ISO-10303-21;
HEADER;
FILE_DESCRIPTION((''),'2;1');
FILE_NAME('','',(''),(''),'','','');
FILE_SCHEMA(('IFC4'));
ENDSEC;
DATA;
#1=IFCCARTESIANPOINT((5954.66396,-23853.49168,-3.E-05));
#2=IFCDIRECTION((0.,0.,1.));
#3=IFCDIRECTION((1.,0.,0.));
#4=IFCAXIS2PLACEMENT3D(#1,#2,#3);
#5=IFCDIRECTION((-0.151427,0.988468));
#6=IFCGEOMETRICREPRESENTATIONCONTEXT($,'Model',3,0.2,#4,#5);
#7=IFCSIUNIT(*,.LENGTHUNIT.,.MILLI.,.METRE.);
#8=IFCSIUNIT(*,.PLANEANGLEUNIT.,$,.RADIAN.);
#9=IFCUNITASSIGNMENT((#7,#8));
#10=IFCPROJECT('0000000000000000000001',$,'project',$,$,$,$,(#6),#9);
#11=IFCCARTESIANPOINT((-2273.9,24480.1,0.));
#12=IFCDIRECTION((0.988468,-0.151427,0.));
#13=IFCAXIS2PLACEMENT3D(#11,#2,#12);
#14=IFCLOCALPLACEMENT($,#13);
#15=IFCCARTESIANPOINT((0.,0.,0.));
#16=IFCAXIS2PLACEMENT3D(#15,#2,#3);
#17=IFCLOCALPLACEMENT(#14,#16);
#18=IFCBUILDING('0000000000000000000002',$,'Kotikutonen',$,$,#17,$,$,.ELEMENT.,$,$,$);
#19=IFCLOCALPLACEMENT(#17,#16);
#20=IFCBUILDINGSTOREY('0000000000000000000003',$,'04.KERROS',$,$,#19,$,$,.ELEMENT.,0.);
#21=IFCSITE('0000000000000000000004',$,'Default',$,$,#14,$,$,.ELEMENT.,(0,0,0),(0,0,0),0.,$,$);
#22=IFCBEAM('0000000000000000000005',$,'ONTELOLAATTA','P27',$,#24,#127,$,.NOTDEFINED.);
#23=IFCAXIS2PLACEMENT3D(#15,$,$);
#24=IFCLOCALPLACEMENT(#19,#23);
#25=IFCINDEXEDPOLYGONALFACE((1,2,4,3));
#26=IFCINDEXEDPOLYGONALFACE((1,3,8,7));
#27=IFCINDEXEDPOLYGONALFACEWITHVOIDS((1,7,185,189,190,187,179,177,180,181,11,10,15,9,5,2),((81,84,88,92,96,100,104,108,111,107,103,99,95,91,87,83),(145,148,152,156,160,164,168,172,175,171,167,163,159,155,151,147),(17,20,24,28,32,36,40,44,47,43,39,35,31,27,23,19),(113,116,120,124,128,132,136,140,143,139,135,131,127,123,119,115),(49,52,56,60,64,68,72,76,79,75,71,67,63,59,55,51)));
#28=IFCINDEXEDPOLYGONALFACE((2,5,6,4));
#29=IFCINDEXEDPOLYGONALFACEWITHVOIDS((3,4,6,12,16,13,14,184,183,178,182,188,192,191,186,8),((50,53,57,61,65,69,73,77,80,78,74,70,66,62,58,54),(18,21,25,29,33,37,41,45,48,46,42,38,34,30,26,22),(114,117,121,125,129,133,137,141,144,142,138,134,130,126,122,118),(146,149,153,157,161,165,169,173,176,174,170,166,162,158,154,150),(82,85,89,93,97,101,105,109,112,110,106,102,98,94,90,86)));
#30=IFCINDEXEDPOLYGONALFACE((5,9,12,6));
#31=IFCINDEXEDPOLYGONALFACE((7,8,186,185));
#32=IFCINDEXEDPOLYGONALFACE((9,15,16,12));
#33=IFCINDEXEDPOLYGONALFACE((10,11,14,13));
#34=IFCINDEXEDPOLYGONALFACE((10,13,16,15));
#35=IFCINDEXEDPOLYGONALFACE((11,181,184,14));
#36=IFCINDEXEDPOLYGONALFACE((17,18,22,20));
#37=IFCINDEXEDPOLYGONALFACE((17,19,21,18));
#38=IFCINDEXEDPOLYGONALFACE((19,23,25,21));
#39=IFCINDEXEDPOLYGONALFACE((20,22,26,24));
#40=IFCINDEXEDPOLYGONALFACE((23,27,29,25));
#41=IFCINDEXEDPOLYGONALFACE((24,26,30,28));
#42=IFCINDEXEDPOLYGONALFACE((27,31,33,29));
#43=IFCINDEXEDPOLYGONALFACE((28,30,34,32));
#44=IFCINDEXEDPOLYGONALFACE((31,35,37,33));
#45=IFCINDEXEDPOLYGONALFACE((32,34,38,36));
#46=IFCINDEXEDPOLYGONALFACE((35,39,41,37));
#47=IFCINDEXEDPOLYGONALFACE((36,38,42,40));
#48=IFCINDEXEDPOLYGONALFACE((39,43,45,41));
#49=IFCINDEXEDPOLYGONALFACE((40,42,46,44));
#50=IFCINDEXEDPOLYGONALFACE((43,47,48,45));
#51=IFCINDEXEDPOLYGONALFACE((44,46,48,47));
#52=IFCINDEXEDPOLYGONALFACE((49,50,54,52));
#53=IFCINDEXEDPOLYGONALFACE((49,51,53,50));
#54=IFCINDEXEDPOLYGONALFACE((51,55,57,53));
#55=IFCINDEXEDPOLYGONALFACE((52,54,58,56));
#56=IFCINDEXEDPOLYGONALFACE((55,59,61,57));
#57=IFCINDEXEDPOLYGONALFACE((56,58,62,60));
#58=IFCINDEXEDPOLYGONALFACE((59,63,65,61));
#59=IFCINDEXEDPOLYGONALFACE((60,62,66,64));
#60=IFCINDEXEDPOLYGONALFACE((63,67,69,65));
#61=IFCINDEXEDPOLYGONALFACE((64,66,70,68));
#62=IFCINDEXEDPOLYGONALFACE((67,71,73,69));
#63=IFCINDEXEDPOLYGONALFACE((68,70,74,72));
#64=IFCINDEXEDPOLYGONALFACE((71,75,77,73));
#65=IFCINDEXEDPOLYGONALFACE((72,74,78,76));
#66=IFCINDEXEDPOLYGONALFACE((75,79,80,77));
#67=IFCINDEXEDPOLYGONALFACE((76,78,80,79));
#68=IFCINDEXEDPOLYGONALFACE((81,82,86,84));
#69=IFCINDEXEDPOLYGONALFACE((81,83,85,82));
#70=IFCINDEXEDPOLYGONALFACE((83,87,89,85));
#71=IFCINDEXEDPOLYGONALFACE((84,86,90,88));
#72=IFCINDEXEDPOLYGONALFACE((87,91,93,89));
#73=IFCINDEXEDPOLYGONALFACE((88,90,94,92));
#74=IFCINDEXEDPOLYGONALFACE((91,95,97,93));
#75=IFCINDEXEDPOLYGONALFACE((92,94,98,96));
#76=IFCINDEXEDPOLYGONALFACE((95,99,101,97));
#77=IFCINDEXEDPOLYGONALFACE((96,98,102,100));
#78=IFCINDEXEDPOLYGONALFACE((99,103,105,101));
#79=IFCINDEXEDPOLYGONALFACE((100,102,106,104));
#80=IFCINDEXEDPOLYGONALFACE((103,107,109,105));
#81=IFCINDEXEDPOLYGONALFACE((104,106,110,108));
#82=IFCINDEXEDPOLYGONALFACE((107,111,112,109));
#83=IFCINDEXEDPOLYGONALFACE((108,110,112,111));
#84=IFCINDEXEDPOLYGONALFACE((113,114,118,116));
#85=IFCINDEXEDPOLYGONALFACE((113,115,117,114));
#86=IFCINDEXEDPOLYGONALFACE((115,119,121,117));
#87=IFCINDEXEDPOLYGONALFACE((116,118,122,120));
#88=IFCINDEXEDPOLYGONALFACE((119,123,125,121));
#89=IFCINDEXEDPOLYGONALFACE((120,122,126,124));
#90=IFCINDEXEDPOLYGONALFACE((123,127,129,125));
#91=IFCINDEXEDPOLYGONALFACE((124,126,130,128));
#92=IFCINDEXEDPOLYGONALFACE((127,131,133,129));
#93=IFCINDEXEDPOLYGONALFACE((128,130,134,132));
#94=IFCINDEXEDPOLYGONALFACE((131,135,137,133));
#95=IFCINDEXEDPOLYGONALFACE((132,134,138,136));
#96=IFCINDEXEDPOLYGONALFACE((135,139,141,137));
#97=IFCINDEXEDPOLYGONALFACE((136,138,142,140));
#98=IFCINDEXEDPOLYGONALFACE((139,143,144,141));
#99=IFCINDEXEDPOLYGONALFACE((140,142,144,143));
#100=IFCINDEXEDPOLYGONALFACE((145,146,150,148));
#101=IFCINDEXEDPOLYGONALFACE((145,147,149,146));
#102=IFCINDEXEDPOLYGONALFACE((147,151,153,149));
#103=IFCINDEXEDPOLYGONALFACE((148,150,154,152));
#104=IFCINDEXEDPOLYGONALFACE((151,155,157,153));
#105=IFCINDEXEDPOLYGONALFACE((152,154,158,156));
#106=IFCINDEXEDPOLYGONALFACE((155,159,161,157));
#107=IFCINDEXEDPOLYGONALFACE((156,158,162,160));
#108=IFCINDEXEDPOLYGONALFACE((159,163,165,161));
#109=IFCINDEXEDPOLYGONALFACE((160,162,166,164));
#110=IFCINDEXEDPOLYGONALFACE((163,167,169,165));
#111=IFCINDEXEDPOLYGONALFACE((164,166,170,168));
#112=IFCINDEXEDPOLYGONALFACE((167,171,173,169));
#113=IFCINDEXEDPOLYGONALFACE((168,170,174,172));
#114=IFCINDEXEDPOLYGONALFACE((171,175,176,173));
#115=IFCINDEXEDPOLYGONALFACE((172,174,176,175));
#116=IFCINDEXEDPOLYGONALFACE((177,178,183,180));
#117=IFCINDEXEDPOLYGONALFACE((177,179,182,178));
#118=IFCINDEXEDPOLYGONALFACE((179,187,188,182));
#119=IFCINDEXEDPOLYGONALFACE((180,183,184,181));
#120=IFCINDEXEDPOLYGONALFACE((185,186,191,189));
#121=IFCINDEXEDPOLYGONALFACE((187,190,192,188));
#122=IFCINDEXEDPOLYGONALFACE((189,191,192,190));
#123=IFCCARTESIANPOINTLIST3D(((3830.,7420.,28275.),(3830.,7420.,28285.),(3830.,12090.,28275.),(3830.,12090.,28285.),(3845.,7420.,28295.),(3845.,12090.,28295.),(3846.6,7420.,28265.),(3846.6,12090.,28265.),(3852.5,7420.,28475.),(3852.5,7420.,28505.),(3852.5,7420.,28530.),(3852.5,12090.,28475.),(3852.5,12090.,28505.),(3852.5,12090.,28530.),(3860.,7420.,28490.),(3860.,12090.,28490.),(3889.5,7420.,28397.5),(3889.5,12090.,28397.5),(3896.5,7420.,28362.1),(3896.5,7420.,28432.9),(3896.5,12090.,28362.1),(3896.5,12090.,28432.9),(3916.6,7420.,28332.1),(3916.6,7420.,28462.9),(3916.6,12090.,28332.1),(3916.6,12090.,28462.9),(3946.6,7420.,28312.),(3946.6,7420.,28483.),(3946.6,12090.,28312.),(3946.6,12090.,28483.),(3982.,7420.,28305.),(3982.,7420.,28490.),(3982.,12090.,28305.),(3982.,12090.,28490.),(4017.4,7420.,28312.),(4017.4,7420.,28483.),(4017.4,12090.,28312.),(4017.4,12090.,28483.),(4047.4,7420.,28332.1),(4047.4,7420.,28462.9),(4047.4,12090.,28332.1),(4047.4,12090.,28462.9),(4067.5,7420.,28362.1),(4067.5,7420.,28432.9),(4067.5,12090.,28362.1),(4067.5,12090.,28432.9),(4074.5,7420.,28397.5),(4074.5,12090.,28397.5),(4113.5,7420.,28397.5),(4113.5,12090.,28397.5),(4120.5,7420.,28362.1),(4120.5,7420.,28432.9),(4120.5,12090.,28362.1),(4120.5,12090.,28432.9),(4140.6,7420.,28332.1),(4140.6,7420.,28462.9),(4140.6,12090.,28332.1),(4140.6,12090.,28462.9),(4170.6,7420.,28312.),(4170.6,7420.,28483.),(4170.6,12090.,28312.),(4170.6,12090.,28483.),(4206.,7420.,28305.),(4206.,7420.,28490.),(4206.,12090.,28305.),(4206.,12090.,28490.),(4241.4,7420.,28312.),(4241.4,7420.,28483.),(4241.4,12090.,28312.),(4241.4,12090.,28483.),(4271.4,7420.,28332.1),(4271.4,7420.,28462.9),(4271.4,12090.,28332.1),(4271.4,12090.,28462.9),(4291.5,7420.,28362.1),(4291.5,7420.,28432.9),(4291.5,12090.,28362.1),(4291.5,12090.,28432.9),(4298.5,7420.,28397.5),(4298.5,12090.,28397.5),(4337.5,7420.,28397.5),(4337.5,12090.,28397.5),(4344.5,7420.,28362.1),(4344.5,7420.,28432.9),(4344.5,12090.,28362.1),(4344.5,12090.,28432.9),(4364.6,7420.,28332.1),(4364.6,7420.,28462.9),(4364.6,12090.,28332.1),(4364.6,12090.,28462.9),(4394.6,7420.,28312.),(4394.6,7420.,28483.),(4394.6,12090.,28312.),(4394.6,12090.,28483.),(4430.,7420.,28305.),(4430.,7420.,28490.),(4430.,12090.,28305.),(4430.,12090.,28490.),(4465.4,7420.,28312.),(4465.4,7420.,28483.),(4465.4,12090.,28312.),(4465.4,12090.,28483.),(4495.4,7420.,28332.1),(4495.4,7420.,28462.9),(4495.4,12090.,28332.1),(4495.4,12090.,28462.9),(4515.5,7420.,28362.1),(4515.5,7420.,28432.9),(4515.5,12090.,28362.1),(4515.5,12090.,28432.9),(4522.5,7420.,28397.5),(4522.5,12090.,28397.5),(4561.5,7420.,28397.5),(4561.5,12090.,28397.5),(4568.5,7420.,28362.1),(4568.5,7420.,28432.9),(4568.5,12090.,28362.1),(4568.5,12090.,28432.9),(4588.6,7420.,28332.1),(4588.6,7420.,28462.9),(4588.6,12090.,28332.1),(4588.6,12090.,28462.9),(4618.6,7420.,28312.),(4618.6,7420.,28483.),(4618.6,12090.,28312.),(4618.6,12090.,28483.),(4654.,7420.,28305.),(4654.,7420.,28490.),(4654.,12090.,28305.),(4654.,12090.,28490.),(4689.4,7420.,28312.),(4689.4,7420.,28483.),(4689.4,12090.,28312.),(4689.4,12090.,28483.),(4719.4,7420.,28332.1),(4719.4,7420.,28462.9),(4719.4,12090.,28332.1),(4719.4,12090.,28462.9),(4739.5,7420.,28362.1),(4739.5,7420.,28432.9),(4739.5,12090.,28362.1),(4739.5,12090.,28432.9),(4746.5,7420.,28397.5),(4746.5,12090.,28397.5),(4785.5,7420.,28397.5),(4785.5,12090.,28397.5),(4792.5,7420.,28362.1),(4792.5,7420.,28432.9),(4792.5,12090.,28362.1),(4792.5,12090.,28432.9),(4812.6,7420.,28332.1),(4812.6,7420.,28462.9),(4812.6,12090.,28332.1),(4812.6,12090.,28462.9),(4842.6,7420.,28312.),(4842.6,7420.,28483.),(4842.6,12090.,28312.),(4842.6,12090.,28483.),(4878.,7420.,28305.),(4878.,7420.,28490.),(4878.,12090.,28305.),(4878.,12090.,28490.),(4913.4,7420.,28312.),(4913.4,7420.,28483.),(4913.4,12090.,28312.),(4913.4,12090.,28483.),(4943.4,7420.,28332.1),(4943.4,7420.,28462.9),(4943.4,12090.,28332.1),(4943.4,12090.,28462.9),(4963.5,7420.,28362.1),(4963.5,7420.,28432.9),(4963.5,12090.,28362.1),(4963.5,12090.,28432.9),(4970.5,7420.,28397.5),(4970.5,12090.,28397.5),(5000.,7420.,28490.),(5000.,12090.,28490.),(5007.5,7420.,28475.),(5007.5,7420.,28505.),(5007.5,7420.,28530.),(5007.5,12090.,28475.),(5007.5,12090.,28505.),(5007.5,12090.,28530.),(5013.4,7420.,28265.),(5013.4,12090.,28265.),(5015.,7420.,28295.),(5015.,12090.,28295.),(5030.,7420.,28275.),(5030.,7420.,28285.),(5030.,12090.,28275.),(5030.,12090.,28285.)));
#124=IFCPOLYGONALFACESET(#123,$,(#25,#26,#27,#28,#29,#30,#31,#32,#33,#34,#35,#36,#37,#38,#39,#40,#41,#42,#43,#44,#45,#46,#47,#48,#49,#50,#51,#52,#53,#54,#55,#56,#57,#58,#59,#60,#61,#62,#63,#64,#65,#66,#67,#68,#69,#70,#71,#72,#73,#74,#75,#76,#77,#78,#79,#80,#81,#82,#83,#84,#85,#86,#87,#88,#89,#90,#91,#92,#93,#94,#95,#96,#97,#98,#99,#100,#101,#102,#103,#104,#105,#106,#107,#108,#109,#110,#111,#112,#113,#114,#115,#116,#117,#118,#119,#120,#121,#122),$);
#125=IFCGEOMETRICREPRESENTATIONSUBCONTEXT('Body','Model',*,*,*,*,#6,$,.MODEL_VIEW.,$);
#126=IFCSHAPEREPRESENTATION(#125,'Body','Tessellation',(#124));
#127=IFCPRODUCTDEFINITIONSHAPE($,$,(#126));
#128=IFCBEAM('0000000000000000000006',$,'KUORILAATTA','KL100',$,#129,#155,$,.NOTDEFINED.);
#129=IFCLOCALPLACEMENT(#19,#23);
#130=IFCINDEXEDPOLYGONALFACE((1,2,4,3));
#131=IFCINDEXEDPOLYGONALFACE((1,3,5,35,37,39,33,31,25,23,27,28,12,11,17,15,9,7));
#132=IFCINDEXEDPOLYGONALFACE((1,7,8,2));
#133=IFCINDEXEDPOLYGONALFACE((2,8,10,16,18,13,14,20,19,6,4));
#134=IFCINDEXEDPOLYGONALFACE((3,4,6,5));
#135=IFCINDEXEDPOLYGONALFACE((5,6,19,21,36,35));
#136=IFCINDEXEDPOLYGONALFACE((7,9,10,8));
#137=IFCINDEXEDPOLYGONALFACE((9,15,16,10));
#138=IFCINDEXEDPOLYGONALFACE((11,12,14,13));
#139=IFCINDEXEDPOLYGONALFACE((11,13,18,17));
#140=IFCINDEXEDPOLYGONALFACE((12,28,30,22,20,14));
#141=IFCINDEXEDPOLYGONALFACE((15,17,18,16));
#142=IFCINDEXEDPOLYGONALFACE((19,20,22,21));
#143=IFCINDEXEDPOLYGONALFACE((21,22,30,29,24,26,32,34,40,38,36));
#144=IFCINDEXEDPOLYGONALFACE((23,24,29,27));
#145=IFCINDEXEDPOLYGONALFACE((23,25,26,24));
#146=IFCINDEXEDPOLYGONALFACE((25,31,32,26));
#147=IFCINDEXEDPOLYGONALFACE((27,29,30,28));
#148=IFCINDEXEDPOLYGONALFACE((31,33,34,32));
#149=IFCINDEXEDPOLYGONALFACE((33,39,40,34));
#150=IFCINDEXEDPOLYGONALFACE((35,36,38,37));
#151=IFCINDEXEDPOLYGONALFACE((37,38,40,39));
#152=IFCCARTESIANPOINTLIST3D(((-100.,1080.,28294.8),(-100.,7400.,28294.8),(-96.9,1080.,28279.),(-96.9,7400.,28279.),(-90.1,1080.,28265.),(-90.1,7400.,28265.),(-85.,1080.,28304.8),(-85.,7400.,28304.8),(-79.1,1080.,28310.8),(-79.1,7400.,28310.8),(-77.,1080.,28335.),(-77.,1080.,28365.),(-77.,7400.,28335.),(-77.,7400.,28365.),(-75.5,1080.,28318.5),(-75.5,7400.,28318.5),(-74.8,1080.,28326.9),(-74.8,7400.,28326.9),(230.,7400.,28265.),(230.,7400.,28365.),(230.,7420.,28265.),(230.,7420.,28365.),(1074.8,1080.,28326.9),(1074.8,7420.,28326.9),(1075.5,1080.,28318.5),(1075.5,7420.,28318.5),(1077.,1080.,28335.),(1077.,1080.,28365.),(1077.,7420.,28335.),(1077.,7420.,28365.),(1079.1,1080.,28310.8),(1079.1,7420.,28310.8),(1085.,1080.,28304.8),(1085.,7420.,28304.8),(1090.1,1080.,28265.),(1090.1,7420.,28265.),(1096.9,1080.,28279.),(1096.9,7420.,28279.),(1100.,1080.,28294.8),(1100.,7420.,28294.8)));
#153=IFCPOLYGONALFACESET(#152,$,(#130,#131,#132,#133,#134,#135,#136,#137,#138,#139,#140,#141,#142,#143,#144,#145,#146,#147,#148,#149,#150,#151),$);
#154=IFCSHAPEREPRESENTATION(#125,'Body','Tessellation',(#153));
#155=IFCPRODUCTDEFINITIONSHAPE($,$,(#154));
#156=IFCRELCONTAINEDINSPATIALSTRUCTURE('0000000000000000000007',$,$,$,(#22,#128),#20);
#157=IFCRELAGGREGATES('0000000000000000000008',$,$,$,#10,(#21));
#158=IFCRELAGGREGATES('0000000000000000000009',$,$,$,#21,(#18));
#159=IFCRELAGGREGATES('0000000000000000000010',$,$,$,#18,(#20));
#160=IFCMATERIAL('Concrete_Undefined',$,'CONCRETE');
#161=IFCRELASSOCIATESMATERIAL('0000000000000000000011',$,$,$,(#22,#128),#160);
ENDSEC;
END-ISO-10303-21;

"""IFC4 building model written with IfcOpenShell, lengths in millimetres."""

from ifc_helpers import new_model, si_unit, direction, frame, origin_with_axes, place, context, subcontext, project, spatial, line, indexed_curve, outline, extrude, material, element, save


model = new_model("IFC4")

# Units and contexts
model_context = context("Model", 3, precision=0.2, world=frame((5954.66396, -23853.49168, -3e-05), z_axis=(0.0, 0.0, 1.0), x_axis=(1.0, 0.0, 0.0)), true_north=direction((-0.151427, 0.988468)))
body_context = subcontext(model_context, "Body", "Model", "MODEL_VIEW")
ifc_project = project(units=[si_unit("LENGTHUNIT", "METRE", prefix="MILLI"), si_unit("PLANEANGLEUNIT", "RADIAN")], contexts=[model_context])

# Site, building, storey
site_placement = place(None, frame((-2273.9, 24480.1, 0.0), z_axis=(0.0, 0.0, 1.0), x_axis=(0.988468, -0.151427, 0.0)))
site = spatial("IfcSite", under=ifc_project, at=site_placement, Name="Default", CompositionType="ELEMENT", RefLatitude=(0, 0, 0), RefLongitude=(0, 0, 0), RefElevation=0.0)
building_placement = place(site_placement, origin_with_axes())
building = spatial("IfcBuilding", under=site, at=building_placement, Name="Kotikutonen", CompositionType="ELEMENT")
storey_placement = place(building_placement, origin_with_axes())
storey = spatial("IfcBuildingStorey", under=building, at=storey_placement, Name="04.KERROS", CompositionType="ELEMENT", Elevation=0.0)

# Beam
ifc_material_1 = material(Name="Concrete_Undefined", Category="CONCRETE")
beam_1_placement = place(storey_placement, frame((4430.0, 12090.0, 28397.5), z_axis=(-1.0, 0.0, 0.0), x_axis=(0.0, -1.0, 0.0)))
element("IfcBeam", 1, at=beam_1_placement, inside=storey, material=ifc_material_1, Name="ONTELOLAATTA", Description="P27", PredefinedType="NOTDEFINED", context=body_context, shape_type="SolidModel", body=[
    extrude(outline(indexed_curve([(-600.0, -122.5), (-583.4, -132.5), (583.4, -132.5), (600.0, -122.5), (600.0, -112.5), (585.0, -102.5), (577.5, 77.5), (570.0, 92.5), (577.5, 107.5), (577.5, 132.5), (-577.5, 132.5), (-577.5, 107.5), (-570.0, 92.5), (-577.5, 77.5), (-585.0, -102.5), (-600.0, -112.5)], segments=[line(1, 2, 3, 4, 5, 6, 7, 8, 9, 10, 11, 12, 13, 14, 15, 16, 1)]), holes=[indexed_curve([(-448.0, -92.5), (-483.4, -85.5), (-513.4, -65.4), (-533.5, -35.4), (-540.5, 0.0), (-533.5, 35.4), (-513.4, 65.4), (-483.4, 85.5), (-448.0, 92.5), (-412.6, 85.5), (-382.6, 65.4), (-362.5, 35.4), (-355.5, 0.0), (-362.5, -35.4), (-382.6, -65.4), (-412.6, -85.5)], segments=[line(1, 2, 3, 4, 5, 6, 7, 8, 9, 10, 11, 12, 13, 14, 15, 16, 1)]), indexed_curve([(-224.0, -92.5), (-259.4, -85.5), (-289.4, -65.4), (-309.5, -35.4), (-316.5, 0.0), (-309.5, 35.4), (-289.4, 65.4), (-259.4, 85.5), (-224.0, 92.5), (-188.6, 85.5), (-158.6, 65.4), (-138.5, 35.4), (-131.5, 0.0), (-138.5, -35.4), (-158.6, -65.4), (-188.6, -85.5)], segments=[line(1, 2, 3, 4, 5, 6, 7, 8, 9, 10, 11, 12, 13, 14, 15, 16, 1)]), indexed_curve([(0.0, -92.5), (-35.4, -85.5), (-65.4, -65.4), (-85.5, -35.4), (-92.5, 0.0), (-85.5, 35.4), (-65.4, 65.4), (-35.4, 85.5), (0.0, 92.5), (35.4, 85.5), (65.4, 65.4), (85.5, 35.4), (92.5, 0.0), (85.5, -35.4), (65.4, -65.4), (35.4, -85.5)], segments=[line(1, 2, 3, 4, 5, 6, 7, 8, 9, 10, 11, 12, 13, 14, 15, 16, 1)]), indexed_curve([(224.0, -92.5), (188.6, -85.5), (158.6, -65.4), (138.5, -35.4), (131.5, 0.0), (138.5, 35.4), (158.6, 65.4), (188.6, 85.5), (224.0, 92.5), (259.4, 85.5), (289.4, 65.4), (309.5, 35.4), (316.5, 0.0), (309.5, -35.4), (289.4, -65.4), (259.4, -85.5)], segments=[line(1, 2, 3, 4, 5, 6, 7, 8, 9, 10, 11, 12, 13, 14, 15, 16, 1)]), indexed_curve([(448.0, -92.5), (412.6, -85.5), (382.6, -65.4), (362.5, -35.4), (355.5, 0.0), (362.5, 35.4), (382.6, 65.4), (412.6, 85.5), (448.0, 92.5), (483.4, 85.5), (513.4, 65.4), (533.5, 35.4), (540.5, 0.0), (533.5, -35.4), (513.4, -65.4), (483.4, -85.5)], segments=[line(1, 2, 3, 4, 5, 6, 7, 8, 9, 10, 11, 12, 13, 14, 15, 16, 1)])]), frame((0.0, 0.0, 0.0), z_axis=(-1.0, 0.0, 0.0), x_axis=(0.0, 0.0, 1.0)), (0.0, 0.0, -1.0), 4670.0),
])

# Beam, voiding feature
beam_2_placement = place(storey_placement, frame((500.0, 7420.0, 28315.0), z_axis=(-1.0, 0.0, 0.0), x_axis=(0.0, -1.0, 0.0)))
beam_2 = element("IfcBeam", 2, at=beam_2_placement, inside=storey, material=ifc_material_1, Name="KUORILAATTA", Description="KL100", PredefinedType="NOTDEFINED", context=body_context, shape_type="SolidModel", body=[
    extrude(outline(indexed_curve([(-596.9, -36.0), (-590.1, -50.0), (590.1, -50.0), (596.9, -36.0), (600.0, -20.2), (585.0, -10.2), (579.1, -4.2), (575.5, 3.5), (574.8, 11.9), (577.0, 20.0), (577.0, 50.0), (-577.0, 50.0), (-577.0, 20.0), (-574.8, 11.9), (-575.5, 3.5), (-579.1, -4.2), (-585.0, -10.2), (-600.0, -20.2)], segments=[line(1, 2, 3, 4, 5, 6, 7, 8, 9, 10, 11, 12, 13, 14, 15, 16, 17, 18, 1)])), frame((0.0, 0.0, 0.0), z_axis=(-1.0, 0.0, 0.0), x_axis=(0.0, 0.0, 1.0)), (0.0, 0.0, -1.0), 6340.0),
])
voiding_feature_1_placement = place(beam_2_placement, frame((20.0, 0.0, 270.0), z_axis=(0.0, 1.0, 0.0), x_axis=(-1.0, 0.0, 0.0)))
element("IfcVoidingFeature", 3, at=voiding_feature_1_placement, cuts=beam_2, Name="Opening", PredefinedType="HOLE", context=body_context, shape_type="SolidModel", body=[
    extrude(outline(indexed_curve([(0.0, 0.0), (270.0, 0.0), (270.0, 580.0), (0.0, 580.0)], segments=[line(1, 2, 3, 4, 1)])), frame((0.0, 0.0, 125.0), z_axis=(0.0, 0.0, 1.0), x_axis=(1.0, 0.0, 0.0)), (0.0, 0.0, -1.0), 250.0),
])

save(model, "model.ifc")
